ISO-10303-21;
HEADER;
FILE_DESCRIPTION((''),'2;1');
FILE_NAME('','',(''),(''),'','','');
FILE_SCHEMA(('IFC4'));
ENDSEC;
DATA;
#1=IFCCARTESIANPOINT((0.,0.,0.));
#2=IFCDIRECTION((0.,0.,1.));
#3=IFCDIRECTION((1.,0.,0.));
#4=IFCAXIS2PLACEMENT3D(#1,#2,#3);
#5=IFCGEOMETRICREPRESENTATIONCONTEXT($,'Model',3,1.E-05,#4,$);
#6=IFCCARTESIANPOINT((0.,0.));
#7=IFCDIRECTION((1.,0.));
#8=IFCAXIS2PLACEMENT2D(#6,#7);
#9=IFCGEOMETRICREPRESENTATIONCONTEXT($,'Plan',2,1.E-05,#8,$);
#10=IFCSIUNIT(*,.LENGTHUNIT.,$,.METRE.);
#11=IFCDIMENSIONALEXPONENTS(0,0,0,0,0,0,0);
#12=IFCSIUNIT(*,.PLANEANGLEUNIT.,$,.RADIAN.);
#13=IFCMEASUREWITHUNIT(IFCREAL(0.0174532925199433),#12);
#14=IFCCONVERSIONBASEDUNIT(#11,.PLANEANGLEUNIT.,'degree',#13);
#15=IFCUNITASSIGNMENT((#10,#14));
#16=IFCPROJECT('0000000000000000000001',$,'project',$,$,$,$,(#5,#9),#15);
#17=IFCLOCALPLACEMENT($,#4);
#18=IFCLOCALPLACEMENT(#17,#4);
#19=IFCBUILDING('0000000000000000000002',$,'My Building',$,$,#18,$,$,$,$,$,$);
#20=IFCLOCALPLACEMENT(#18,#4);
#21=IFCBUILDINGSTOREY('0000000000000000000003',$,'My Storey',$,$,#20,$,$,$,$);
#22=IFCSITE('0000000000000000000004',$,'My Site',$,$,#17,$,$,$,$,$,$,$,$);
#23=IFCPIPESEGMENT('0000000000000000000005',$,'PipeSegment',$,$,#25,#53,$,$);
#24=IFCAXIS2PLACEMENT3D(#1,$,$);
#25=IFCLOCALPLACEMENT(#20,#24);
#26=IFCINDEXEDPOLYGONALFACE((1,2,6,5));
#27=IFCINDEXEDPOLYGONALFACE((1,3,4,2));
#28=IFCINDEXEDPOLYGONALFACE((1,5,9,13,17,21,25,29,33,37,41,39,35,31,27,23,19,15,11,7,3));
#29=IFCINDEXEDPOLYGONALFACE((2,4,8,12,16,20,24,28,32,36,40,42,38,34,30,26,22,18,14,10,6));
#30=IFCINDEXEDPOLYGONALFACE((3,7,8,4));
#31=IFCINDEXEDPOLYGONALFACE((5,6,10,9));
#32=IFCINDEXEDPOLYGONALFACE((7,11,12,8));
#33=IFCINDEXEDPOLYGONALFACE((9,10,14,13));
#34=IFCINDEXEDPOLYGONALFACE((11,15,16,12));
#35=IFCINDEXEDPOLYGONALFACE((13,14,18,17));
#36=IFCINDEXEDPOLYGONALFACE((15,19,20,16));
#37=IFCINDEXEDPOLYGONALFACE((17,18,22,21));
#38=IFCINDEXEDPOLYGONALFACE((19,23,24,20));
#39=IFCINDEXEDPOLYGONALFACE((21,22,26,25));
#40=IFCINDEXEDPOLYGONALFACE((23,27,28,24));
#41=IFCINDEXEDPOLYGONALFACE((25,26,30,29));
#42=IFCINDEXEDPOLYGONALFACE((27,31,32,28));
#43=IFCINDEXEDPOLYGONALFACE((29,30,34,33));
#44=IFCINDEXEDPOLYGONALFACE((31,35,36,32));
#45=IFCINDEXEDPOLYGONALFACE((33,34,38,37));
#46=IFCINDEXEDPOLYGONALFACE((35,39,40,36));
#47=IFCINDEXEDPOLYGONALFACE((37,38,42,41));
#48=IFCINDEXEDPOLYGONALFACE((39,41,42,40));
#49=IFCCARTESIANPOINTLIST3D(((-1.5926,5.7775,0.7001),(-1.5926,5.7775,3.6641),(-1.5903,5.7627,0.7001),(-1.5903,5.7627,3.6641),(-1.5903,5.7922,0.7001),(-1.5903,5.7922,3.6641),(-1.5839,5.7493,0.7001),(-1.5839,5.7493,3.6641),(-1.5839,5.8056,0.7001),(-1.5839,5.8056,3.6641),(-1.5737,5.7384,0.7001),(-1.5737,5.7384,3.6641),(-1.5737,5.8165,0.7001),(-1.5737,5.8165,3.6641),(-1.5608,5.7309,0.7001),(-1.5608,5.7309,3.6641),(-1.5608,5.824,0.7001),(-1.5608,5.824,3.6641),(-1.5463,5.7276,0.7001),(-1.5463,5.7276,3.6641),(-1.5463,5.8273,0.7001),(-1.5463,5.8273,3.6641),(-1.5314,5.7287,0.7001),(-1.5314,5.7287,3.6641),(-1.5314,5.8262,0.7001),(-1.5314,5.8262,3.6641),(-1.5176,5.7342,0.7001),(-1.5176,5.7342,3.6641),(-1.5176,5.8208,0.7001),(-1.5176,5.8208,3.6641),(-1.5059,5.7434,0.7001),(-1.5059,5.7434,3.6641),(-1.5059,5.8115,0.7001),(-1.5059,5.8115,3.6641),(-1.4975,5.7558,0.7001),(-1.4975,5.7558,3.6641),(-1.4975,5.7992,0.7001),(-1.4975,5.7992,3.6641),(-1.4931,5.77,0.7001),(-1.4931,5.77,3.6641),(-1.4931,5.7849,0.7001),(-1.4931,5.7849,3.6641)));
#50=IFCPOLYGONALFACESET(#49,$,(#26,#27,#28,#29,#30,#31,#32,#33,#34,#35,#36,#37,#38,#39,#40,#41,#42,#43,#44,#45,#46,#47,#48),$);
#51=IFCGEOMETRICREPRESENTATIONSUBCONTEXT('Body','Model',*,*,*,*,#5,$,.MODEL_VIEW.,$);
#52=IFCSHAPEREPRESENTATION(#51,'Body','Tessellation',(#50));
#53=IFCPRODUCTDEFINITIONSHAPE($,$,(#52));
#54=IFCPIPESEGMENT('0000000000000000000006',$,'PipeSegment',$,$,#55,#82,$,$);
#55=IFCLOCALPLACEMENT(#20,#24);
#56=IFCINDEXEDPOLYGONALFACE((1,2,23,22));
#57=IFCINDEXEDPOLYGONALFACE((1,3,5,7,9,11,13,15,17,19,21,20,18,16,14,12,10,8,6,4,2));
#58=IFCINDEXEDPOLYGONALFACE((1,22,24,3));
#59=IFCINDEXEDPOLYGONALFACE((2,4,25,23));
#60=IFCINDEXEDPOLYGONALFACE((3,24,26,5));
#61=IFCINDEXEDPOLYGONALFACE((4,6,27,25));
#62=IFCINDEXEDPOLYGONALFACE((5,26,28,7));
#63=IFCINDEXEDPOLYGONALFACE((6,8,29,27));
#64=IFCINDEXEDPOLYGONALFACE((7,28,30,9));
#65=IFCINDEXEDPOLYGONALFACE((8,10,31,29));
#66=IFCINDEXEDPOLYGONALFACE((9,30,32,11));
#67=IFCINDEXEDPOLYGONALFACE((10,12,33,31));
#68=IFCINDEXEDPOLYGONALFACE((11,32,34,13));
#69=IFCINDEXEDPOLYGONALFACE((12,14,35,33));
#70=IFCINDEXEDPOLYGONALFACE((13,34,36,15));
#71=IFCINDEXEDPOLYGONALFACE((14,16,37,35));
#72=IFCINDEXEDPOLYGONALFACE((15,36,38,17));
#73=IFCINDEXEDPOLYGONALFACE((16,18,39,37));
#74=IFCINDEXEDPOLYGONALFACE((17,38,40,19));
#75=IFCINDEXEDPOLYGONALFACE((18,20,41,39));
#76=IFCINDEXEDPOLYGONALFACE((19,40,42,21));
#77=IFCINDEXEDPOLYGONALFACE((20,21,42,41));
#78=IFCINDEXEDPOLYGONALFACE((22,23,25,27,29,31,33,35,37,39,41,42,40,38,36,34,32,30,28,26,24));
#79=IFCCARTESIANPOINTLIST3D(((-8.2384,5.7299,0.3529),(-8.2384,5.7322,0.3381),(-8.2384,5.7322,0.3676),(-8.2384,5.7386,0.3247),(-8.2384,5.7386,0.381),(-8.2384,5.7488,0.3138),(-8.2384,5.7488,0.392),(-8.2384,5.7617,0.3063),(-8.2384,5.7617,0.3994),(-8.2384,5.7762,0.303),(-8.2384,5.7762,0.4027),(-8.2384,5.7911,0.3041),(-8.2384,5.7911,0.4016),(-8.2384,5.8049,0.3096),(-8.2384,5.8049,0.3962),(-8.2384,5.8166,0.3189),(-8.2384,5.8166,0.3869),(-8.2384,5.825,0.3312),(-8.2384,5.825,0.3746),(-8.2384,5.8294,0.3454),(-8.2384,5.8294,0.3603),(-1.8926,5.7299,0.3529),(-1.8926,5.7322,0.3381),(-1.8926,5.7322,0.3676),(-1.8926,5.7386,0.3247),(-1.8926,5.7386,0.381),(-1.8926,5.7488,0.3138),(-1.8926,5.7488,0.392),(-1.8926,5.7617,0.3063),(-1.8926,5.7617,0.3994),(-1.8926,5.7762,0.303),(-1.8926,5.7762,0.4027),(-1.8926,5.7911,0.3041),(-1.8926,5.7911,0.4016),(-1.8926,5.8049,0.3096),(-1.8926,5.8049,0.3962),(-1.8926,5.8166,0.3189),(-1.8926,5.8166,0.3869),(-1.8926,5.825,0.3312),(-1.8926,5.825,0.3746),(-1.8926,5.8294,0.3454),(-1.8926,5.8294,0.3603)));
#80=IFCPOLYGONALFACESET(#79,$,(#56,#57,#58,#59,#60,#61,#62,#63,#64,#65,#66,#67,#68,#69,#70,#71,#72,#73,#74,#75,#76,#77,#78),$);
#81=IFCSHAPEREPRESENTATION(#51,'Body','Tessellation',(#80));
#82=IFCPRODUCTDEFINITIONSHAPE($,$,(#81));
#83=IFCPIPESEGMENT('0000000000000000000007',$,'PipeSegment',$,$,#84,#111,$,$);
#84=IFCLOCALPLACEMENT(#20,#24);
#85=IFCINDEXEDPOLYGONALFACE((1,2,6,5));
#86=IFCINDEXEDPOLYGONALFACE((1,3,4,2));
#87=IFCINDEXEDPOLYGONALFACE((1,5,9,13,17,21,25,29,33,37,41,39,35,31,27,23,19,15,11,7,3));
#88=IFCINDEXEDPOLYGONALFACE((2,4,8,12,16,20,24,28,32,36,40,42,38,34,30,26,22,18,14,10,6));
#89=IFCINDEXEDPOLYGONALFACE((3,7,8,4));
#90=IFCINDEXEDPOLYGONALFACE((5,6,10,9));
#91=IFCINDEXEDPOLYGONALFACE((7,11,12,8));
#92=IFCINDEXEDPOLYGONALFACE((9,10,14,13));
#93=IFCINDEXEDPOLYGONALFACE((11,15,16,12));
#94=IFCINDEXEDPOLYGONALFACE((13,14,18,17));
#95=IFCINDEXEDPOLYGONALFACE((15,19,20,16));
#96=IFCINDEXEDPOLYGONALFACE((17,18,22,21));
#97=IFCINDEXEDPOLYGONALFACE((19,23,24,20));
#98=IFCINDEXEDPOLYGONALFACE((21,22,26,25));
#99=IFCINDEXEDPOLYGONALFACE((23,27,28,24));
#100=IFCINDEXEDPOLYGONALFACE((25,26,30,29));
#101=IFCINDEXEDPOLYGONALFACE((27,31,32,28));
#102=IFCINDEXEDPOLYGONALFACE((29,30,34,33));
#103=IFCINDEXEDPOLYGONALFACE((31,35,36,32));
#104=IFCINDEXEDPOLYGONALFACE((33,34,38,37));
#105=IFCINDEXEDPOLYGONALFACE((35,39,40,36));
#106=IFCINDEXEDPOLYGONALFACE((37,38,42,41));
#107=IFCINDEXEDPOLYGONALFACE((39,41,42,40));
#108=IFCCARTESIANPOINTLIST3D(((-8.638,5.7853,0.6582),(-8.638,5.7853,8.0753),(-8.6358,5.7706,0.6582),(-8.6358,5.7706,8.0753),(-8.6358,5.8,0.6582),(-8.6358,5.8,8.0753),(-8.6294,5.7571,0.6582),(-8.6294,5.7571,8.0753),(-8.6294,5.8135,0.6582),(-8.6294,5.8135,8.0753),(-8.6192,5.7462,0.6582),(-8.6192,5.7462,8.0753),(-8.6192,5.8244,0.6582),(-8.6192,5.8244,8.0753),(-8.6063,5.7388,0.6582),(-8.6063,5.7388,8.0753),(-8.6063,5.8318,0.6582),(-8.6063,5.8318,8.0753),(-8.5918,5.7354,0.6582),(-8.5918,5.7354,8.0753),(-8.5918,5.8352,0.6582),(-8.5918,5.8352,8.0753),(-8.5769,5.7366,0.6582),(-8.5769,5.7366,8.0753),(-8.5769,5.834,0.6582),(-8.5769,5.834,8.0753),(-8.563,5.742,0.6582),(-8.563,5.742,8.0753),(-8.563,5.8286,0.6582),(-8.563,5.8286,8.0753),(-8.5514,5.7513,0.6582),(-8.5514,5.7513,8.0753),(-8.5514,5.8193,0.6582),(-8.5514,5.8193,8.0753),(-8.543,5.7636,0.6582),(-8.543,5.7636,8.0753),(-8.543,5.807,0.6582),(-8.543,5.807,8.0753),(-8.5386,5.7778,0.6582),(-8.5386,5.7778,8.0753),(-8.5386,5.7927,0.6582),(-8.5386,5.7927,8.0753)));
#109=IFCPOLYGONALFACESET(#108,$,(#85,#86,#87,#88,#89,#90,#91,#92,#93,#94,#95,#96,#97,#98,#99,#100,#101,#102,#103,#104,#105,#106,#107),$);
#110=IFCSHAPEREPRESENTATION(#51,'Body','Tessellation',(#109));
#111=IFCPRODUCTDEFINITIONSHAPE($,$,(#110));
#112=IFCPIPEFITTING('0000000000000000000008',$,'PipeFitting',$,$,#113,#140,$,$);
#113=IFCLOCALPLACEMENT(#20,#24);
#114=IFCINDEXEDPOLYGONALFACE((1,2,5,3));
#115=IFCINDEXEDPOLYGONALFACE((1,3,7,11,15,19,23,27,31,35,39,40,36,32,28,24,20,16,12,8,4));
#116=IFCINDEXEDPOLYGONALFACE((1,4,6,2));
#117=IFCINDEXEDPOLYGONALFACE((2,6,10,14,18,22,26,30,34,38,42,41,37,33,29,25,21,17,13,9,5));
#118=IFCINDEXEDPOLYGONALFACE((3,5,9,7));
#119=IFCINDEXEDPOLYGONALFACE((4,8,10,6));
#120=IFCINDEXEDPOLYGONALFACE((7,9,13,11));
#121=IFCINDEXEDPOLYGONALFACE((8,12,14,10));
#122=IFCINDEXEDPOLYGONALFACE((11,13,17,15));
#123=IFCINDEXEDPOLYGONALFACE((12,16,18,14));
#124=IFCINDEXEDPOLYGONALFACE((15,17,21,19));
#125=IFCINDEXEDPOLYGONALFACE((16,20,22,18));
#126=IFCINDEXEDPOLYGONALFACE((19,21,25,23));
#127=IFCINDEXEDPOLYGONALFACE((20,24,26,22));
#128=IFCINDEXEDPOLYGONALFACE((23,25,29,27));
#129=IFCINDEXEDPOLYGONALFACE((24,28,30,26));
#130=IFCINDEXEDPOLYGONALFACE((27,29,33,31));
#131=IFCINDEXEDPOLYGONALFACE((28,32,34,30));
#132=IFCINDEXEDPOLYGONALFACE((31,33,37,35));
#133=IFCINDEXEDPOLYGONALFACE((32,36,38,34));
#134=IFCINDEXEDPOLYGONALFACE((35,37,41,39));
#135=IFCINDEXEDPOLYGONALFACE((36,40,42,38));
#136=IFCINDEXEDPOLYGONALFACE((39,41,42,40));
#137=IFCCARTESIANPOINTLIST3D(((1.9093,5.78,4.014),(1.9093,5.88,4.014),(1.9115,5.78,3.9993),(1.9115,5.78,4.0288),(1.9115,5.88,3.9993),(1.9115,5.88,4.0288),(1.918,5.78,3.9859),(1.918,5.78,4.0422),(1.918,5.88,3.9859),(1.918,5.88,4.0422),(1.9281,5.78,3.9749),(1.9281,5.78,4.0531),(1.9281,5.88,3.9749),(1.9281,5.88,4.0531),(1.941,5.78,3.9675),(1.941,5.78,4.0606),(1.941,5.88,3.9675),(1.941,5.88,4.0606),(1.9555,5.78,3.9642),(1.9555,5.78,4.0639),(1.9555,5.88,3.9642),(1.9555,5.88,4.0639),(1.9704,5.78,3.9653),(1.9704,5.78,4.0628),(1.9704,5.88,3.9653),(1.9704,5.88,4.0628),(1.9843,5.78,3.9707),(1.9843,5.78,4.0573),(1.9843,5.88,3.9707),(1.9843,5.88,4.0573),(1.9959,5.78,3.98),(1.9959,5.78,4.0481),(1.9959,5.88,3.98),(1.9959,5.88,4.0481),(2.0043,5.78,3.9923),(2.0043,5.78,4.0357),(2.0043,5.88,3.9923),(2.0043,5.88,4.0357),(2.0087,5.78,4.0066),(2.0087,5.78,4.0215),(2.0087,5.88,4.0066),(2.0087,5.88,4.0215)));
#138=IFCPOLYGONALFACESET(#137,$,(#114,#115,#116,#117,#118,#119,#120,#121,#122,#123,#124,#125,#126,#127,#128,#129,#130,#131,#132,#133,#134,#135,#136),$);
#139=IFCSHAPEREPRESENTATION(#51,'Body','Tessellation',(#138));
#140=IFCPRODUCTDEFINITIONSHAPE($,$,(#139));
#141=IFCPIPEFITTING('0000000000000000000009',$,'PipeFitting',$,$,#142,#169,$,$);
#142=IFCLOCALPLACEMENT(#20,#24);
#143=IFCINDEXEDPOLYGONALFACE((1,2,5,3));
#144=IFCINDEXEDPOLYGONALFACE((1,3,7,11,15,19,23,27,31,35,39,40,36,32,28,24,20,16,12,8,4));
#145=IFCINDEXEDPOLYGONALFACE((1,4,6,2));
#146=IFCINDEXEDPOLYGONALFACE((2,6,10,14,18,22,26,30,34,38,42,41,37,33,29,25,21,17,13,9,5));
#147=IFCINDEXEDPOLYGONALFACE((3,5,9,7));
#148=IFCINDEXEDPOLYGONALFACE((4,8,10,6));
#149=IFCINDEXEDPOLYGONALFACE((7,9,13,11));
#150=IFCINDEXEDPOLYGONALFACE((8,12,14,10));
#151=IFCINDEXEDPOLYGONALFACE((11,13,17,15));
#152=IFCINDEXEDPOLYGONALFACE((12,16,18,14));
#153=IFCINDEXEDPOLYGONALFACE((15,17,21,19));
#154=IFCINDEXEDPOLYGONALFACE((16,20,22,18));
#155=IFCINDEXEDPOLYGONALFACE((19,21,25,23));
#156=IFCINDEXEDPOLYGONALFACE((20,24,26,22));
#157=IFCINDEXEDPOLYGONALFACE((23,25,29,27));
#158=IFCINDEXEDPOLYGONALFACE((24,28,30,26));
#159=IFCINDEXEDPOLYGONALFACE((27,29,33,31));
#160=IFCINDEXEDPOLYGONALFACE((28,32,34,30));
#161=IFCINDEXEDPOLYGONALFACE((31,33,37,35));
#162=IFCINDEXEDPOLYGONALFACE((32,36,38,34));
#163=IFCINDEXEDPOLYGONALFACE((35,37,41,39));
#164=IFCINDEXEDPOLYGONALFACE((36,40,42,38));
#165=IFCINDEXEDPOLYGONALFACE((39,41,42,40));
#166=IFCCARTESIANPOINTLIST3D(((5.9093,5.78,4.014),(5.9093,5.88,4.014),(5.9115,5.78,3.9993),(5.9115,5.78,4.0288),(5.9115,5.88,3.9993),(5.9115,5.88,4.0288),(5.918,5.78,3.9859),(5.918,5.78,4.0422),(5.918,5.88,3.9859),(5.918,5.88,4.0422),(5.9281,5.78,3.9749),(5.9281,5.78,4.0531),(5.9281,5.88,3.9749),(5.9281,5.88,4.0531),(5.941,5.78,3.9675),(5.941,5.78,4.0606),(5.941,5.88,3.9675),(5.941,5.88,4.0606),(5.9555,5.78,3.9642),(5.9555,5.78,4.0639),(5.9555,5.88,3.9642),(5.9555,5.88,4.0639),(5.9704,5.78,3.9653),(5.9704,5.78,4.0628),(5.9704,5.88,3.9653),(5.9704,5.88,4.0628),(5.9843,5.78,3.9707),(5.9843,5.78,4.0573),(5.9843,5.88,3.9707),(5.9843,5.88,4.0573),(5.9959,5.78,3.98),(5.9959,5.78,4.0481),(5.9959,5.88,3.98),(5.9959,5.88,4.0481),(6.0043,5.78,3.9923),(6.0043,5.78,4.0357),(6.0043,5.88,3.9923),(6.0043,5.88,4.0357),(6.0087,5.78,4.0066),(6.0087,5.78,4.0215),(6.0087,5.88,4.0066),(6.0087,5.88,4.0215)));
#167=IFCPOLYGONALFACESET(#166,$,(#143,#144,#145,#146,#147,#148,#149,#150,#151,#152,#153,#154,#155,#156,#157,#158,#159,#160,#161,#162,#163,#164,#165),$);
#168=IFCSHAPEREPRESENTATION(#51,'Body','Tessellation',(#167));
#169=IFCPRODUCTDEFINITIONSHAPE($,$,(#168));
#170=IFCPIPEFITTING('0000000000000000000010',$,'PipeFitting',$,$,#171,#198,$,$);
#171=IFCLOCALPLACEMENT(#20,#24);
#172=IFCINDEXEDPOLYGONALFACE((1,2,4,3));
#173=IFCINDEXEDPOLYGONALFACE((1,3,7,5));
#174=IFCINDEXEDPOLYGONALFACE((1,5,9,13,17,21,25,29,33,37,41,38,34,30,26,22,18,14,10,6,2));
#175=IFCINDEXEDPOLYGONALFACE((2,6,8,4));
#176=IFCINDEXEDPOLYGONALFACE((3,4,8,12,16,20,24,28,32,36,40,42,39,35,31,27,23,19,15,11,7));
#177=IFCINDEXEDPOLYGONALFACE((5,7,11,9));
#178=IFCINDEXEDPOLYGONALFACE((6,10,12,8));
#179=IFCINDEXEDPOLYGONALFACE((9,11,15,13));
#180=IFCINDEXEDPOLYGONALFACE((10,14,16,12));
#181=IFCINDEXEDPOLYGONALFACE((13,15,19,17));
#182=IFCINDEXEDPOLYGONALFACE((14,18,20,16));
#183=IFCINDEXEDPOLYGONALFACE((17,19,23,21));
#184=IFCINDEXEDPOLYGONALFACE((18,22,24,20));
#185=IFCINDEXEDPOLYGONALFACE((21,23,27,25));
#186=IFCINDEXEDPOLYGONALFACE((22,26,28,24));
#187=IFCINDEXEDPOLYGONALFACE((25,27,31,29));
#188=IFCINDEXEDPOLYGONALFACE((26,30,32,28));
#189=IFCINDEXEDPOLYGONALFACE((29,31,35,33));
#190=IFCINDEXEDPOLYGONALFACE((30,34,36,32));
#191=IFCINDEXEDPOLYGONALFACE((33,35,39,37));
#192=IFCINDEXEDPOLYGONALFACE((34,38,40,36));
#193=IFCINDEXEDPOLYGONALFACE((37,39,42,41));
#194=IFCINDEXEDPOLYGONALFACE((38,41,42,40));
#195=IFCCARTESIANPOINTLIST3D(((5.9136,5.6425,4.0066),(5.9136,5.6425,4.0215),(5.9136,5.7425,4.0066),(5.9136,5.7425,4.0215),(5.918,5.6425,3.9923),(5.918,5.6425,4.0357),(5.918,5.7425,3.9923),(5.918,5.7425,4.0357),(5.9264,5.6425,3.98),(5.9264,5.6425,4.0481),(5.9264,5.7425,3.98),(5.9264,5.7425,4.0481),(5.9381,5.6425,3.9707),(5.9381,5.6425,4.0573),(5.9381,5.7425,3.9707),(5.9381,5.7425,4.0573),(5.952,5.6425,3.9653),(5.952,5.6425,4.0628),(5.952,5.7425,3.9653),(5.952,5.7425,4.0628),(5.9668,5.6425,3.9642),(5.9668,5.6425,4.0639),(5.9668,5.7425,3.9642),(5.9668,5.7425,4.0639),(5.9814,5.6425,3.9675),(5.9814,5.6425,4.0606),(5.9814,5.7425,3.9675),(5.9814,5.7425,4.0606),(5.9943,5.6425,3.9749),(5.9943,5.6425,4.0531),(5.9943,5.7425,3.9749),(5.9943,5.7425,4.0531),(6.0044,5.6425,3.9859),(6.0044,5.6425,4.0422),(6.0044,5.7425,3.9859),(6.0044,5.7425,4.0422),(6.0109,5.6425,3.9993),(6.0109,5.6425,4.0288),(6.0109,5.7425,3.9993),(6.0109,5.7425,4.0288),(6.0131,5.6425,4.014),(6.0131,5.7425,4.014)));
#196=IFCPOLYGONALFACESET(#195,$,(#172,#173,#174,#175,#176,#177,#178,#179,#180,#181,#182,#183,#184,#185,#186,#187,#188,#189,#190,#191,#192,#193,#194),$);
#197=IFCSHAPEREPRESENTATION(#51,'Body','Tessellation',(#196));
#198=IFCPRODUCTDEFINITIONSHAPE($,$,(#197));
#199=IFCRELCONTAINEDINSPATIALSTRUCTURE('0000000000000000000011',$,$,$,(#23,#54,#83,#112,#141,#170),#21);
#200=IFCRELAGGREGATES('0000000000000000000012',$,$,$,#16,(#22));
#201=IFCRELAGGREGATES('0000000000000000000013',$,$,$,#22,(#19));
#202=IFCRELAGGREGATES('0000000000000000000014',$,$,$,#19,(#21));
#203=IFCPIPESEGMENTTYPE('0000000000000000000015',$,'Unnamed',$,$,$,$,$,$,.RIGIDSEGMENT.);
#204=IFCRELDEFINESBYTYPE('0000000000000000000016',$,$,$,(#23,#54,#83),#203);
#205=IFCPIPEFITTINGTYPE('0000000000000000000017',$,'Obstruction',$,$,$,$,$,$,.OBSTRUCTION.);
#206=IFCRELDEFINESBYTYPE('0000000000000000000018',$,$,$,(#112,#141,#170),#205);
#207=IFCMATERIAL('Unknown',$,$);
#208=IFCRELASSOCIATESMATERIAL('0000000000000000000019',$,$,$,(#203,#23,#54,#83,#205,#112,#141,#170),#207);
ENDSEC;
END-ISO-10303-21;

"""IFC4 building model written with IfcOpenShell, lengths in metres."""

from ifc_helpers import new_model, entity, si_unit, converted_unit, frame, origin_with_axes, origin_2d_with_axis, place, context, subcontext, project, spatial, circle, extrude, material, material_profile, profile_set, profile_usage, type_object, element, save


model = new_model("IFC4")

# Units and contexts
model_context = context("Model", 3, precision=1e-05, world=origin_with_axes())
plan_context = context("Plan", 2, precision=1e-05, world=origin_2d_with_axis())
body_context = subcontext(model_context, "Body", "Model", "MODEL_VIEW")
ifc_project = project(units=[si_unit("LENGTHUNIT", "METRE"), converted_unit("PLANEANGLEUNIT", "degree", entity("IfcReal", 0.0174532925199433), si_unit("PLANEANGLEUNIT", "RADIAN"), dimensions=[0, 0, 0, 0, 0, 0, 0])], contexts=[model_context, plan_context])

# Site, building, storey
site_placement = place(None, origin_with_axes())
site = spatial("IfcSite", under=ifc_project, at=site_placement, Name="My Site")
building_placement = place(site_placement, origin_with_axes())
building = spatial("IfcBuilding", under=site, at=building_placement, Name="My Building")
storey_placement = place(building_placement, origin_with_axes())
storey = spatial("IfcBuildingStorey", under=building, at=storey_placement, Name="My Storey")

# Shared definitions
ifc_material = material(Name="Unknown")

# Pipe segments
ifc_material_profile_1 = material_profile(ifc_material, circle(Radius=0.05))
ifc_profile_set_1 = profile_set([ifc_material_profile_1])
pipe_segment_type = type_object("IfcPipeSegmentType", Name="Unnamed", PredefinedType="RIGIDSEGMENT", material=ifc_profile_set_1)
ifc_profile_usage_1 = profile_usage(ifc_profile_set_1, cardinal=5)
pipe_segment_1_placement = place(storey_placement, frame((-1.5426, 5.7775, 3.6641), z_axis=(0.0, 0.0, -1.0), x_axis=(-1.0, 0.0, 0.0)))
element("IfcPipeSegment", 1, at=pipe_segment_1_placement, inside=storey, type_object=pipe_segment_type, material=ifc_profile_usage_1, Name="PipeSegment", context=body_context, shape_type="SweptSolid", body=[
    extrude(circle(Radius=0.05), origin_with_axes(), (0.0, 0.0, 1.0), 2.964),
])
ifc_profile_usage_2 = profile_usage(ifc_profile_set_1, cardinal=5)
pipe_segment_2_placement = place(storey_placement, frame((-1.8926, 5.7799, 0.3529), z_axis=(-1.0, 0.0, 0.0), x_axis=(0.0, -1.0, 0.0)))
element("IfcPipeSegment", 2, at=pipe_segment_2_placement, inside=storey, type_object=pipe_segment_type, material=ifc_profile_usage_2, Name="PipeSegment", context=body_context, shape_type="SweptSolid", body=[
    extrude(circle(Radius=0.05), origin_with_axes(), (0.0, 0.0, 1.0), 6.3458),
])
ifc_profile_usage_3 = profile_usage(ifc_profile_set_1, cardinal=5)
pipe_segment_3_placement = place(storey_placement, frame((-8.588, 5.7853, 0.6582), z_axis=(0.0, 0.0, 1.0), x_axis=(-1.0, 0.0, 0.0)))
element("IfcPipeSegment", 3, at=pipe_segment_3_placement, inside=storey, type_object=pipe_segment_type, material=ifc_profile_usage_3, Name="PipeSegment", context=body_context, shape_type="SweptSolid", body=[
    extrude(circle(Radius=0.05), origin_with_axes(), (0.0, 0.0, 1.0), 7.417),
])

# Pipe fittings
ifc_material_profile_2 = material_profile(ifc_material, circle(Radius=0.05))
ifc_profile_set_2 = profile_set([ifc_material_profile_2])
ifc_profile_usage_4 = profile_usage(ifc_profile_set_2, cardinal=5)
pipe_fitting_type_1 = type_object("IfcPipeFittingType", Name="Obstruction", PredefinedType="OBSTRUCTION", material=ifc_profile_set_2)
pipe_fitting_1_placement = place(storey_placement, frame((1.9593, 5.78, 4.014), z_axis=(0.0, 1.0, 0.0), x_axis=(-1.0, 0.0, 0.0)))
element("IfcPipeFitting", 4, at=pipe_fitting_1_placement, inside=storey, type_object=pipe_fitting_type_1, material=ifc_profile_usage_4, Name="PipeFitting", context=body_context, shape_type="SweptSolid", body=[
    extrude(circle(Radius=0.05), origin_with_axes(), (0.0, 0.0, 1.0), 0.1),
])
ifc_profile_usage_5 = profile_usage(ifc_profile_set_2, cardinal=5)
pipe_fitting_2_placement = place(storey_placement, frame((5.9593, 5.78, 4.014), z_axis=(0.0, 1.0, 0.0), x_axis=(-1.0, 0.0, 0.0)))
element("IfcPipeFitting", 5, at=pipe_fitting_2_placement, inside=storey, type_object=pipe_fitting_type_1, material=ifc_profile_usage_5, Name="PipeFitting", context=body_context, shape_type="SweptSolid", body=[
    extrude(circle(Radius=0.05), origin_with_axes(), (0.0, 0.0, 1.0), 0.1),
])
ifc_profile_usage_6 = profile_usage(ifc_profile_set_2, cardinal=5)
pipe_fitting_3_placement = place(storey_placement, frame((5.9631, 5.7425, 4.014), z_axis=(0.0, -1.0, 0.0), x_axis=(1.0, 0.0, 0.0)))
element("IfcPipeFitting", 6, at=pipe_fitting_3_placement, inside=storey, type_object=pipe_fitting_type_1, material=ifc_profile_usage_6, Name="PipeFitting", context=body_context, shape_type="SweptSolid", body=[
    extrude(circle(Radius=0.05), origin_with_axes(), (0.0, 0.0, 1.0), 0.1),
])

save(model, "model.ifc")
